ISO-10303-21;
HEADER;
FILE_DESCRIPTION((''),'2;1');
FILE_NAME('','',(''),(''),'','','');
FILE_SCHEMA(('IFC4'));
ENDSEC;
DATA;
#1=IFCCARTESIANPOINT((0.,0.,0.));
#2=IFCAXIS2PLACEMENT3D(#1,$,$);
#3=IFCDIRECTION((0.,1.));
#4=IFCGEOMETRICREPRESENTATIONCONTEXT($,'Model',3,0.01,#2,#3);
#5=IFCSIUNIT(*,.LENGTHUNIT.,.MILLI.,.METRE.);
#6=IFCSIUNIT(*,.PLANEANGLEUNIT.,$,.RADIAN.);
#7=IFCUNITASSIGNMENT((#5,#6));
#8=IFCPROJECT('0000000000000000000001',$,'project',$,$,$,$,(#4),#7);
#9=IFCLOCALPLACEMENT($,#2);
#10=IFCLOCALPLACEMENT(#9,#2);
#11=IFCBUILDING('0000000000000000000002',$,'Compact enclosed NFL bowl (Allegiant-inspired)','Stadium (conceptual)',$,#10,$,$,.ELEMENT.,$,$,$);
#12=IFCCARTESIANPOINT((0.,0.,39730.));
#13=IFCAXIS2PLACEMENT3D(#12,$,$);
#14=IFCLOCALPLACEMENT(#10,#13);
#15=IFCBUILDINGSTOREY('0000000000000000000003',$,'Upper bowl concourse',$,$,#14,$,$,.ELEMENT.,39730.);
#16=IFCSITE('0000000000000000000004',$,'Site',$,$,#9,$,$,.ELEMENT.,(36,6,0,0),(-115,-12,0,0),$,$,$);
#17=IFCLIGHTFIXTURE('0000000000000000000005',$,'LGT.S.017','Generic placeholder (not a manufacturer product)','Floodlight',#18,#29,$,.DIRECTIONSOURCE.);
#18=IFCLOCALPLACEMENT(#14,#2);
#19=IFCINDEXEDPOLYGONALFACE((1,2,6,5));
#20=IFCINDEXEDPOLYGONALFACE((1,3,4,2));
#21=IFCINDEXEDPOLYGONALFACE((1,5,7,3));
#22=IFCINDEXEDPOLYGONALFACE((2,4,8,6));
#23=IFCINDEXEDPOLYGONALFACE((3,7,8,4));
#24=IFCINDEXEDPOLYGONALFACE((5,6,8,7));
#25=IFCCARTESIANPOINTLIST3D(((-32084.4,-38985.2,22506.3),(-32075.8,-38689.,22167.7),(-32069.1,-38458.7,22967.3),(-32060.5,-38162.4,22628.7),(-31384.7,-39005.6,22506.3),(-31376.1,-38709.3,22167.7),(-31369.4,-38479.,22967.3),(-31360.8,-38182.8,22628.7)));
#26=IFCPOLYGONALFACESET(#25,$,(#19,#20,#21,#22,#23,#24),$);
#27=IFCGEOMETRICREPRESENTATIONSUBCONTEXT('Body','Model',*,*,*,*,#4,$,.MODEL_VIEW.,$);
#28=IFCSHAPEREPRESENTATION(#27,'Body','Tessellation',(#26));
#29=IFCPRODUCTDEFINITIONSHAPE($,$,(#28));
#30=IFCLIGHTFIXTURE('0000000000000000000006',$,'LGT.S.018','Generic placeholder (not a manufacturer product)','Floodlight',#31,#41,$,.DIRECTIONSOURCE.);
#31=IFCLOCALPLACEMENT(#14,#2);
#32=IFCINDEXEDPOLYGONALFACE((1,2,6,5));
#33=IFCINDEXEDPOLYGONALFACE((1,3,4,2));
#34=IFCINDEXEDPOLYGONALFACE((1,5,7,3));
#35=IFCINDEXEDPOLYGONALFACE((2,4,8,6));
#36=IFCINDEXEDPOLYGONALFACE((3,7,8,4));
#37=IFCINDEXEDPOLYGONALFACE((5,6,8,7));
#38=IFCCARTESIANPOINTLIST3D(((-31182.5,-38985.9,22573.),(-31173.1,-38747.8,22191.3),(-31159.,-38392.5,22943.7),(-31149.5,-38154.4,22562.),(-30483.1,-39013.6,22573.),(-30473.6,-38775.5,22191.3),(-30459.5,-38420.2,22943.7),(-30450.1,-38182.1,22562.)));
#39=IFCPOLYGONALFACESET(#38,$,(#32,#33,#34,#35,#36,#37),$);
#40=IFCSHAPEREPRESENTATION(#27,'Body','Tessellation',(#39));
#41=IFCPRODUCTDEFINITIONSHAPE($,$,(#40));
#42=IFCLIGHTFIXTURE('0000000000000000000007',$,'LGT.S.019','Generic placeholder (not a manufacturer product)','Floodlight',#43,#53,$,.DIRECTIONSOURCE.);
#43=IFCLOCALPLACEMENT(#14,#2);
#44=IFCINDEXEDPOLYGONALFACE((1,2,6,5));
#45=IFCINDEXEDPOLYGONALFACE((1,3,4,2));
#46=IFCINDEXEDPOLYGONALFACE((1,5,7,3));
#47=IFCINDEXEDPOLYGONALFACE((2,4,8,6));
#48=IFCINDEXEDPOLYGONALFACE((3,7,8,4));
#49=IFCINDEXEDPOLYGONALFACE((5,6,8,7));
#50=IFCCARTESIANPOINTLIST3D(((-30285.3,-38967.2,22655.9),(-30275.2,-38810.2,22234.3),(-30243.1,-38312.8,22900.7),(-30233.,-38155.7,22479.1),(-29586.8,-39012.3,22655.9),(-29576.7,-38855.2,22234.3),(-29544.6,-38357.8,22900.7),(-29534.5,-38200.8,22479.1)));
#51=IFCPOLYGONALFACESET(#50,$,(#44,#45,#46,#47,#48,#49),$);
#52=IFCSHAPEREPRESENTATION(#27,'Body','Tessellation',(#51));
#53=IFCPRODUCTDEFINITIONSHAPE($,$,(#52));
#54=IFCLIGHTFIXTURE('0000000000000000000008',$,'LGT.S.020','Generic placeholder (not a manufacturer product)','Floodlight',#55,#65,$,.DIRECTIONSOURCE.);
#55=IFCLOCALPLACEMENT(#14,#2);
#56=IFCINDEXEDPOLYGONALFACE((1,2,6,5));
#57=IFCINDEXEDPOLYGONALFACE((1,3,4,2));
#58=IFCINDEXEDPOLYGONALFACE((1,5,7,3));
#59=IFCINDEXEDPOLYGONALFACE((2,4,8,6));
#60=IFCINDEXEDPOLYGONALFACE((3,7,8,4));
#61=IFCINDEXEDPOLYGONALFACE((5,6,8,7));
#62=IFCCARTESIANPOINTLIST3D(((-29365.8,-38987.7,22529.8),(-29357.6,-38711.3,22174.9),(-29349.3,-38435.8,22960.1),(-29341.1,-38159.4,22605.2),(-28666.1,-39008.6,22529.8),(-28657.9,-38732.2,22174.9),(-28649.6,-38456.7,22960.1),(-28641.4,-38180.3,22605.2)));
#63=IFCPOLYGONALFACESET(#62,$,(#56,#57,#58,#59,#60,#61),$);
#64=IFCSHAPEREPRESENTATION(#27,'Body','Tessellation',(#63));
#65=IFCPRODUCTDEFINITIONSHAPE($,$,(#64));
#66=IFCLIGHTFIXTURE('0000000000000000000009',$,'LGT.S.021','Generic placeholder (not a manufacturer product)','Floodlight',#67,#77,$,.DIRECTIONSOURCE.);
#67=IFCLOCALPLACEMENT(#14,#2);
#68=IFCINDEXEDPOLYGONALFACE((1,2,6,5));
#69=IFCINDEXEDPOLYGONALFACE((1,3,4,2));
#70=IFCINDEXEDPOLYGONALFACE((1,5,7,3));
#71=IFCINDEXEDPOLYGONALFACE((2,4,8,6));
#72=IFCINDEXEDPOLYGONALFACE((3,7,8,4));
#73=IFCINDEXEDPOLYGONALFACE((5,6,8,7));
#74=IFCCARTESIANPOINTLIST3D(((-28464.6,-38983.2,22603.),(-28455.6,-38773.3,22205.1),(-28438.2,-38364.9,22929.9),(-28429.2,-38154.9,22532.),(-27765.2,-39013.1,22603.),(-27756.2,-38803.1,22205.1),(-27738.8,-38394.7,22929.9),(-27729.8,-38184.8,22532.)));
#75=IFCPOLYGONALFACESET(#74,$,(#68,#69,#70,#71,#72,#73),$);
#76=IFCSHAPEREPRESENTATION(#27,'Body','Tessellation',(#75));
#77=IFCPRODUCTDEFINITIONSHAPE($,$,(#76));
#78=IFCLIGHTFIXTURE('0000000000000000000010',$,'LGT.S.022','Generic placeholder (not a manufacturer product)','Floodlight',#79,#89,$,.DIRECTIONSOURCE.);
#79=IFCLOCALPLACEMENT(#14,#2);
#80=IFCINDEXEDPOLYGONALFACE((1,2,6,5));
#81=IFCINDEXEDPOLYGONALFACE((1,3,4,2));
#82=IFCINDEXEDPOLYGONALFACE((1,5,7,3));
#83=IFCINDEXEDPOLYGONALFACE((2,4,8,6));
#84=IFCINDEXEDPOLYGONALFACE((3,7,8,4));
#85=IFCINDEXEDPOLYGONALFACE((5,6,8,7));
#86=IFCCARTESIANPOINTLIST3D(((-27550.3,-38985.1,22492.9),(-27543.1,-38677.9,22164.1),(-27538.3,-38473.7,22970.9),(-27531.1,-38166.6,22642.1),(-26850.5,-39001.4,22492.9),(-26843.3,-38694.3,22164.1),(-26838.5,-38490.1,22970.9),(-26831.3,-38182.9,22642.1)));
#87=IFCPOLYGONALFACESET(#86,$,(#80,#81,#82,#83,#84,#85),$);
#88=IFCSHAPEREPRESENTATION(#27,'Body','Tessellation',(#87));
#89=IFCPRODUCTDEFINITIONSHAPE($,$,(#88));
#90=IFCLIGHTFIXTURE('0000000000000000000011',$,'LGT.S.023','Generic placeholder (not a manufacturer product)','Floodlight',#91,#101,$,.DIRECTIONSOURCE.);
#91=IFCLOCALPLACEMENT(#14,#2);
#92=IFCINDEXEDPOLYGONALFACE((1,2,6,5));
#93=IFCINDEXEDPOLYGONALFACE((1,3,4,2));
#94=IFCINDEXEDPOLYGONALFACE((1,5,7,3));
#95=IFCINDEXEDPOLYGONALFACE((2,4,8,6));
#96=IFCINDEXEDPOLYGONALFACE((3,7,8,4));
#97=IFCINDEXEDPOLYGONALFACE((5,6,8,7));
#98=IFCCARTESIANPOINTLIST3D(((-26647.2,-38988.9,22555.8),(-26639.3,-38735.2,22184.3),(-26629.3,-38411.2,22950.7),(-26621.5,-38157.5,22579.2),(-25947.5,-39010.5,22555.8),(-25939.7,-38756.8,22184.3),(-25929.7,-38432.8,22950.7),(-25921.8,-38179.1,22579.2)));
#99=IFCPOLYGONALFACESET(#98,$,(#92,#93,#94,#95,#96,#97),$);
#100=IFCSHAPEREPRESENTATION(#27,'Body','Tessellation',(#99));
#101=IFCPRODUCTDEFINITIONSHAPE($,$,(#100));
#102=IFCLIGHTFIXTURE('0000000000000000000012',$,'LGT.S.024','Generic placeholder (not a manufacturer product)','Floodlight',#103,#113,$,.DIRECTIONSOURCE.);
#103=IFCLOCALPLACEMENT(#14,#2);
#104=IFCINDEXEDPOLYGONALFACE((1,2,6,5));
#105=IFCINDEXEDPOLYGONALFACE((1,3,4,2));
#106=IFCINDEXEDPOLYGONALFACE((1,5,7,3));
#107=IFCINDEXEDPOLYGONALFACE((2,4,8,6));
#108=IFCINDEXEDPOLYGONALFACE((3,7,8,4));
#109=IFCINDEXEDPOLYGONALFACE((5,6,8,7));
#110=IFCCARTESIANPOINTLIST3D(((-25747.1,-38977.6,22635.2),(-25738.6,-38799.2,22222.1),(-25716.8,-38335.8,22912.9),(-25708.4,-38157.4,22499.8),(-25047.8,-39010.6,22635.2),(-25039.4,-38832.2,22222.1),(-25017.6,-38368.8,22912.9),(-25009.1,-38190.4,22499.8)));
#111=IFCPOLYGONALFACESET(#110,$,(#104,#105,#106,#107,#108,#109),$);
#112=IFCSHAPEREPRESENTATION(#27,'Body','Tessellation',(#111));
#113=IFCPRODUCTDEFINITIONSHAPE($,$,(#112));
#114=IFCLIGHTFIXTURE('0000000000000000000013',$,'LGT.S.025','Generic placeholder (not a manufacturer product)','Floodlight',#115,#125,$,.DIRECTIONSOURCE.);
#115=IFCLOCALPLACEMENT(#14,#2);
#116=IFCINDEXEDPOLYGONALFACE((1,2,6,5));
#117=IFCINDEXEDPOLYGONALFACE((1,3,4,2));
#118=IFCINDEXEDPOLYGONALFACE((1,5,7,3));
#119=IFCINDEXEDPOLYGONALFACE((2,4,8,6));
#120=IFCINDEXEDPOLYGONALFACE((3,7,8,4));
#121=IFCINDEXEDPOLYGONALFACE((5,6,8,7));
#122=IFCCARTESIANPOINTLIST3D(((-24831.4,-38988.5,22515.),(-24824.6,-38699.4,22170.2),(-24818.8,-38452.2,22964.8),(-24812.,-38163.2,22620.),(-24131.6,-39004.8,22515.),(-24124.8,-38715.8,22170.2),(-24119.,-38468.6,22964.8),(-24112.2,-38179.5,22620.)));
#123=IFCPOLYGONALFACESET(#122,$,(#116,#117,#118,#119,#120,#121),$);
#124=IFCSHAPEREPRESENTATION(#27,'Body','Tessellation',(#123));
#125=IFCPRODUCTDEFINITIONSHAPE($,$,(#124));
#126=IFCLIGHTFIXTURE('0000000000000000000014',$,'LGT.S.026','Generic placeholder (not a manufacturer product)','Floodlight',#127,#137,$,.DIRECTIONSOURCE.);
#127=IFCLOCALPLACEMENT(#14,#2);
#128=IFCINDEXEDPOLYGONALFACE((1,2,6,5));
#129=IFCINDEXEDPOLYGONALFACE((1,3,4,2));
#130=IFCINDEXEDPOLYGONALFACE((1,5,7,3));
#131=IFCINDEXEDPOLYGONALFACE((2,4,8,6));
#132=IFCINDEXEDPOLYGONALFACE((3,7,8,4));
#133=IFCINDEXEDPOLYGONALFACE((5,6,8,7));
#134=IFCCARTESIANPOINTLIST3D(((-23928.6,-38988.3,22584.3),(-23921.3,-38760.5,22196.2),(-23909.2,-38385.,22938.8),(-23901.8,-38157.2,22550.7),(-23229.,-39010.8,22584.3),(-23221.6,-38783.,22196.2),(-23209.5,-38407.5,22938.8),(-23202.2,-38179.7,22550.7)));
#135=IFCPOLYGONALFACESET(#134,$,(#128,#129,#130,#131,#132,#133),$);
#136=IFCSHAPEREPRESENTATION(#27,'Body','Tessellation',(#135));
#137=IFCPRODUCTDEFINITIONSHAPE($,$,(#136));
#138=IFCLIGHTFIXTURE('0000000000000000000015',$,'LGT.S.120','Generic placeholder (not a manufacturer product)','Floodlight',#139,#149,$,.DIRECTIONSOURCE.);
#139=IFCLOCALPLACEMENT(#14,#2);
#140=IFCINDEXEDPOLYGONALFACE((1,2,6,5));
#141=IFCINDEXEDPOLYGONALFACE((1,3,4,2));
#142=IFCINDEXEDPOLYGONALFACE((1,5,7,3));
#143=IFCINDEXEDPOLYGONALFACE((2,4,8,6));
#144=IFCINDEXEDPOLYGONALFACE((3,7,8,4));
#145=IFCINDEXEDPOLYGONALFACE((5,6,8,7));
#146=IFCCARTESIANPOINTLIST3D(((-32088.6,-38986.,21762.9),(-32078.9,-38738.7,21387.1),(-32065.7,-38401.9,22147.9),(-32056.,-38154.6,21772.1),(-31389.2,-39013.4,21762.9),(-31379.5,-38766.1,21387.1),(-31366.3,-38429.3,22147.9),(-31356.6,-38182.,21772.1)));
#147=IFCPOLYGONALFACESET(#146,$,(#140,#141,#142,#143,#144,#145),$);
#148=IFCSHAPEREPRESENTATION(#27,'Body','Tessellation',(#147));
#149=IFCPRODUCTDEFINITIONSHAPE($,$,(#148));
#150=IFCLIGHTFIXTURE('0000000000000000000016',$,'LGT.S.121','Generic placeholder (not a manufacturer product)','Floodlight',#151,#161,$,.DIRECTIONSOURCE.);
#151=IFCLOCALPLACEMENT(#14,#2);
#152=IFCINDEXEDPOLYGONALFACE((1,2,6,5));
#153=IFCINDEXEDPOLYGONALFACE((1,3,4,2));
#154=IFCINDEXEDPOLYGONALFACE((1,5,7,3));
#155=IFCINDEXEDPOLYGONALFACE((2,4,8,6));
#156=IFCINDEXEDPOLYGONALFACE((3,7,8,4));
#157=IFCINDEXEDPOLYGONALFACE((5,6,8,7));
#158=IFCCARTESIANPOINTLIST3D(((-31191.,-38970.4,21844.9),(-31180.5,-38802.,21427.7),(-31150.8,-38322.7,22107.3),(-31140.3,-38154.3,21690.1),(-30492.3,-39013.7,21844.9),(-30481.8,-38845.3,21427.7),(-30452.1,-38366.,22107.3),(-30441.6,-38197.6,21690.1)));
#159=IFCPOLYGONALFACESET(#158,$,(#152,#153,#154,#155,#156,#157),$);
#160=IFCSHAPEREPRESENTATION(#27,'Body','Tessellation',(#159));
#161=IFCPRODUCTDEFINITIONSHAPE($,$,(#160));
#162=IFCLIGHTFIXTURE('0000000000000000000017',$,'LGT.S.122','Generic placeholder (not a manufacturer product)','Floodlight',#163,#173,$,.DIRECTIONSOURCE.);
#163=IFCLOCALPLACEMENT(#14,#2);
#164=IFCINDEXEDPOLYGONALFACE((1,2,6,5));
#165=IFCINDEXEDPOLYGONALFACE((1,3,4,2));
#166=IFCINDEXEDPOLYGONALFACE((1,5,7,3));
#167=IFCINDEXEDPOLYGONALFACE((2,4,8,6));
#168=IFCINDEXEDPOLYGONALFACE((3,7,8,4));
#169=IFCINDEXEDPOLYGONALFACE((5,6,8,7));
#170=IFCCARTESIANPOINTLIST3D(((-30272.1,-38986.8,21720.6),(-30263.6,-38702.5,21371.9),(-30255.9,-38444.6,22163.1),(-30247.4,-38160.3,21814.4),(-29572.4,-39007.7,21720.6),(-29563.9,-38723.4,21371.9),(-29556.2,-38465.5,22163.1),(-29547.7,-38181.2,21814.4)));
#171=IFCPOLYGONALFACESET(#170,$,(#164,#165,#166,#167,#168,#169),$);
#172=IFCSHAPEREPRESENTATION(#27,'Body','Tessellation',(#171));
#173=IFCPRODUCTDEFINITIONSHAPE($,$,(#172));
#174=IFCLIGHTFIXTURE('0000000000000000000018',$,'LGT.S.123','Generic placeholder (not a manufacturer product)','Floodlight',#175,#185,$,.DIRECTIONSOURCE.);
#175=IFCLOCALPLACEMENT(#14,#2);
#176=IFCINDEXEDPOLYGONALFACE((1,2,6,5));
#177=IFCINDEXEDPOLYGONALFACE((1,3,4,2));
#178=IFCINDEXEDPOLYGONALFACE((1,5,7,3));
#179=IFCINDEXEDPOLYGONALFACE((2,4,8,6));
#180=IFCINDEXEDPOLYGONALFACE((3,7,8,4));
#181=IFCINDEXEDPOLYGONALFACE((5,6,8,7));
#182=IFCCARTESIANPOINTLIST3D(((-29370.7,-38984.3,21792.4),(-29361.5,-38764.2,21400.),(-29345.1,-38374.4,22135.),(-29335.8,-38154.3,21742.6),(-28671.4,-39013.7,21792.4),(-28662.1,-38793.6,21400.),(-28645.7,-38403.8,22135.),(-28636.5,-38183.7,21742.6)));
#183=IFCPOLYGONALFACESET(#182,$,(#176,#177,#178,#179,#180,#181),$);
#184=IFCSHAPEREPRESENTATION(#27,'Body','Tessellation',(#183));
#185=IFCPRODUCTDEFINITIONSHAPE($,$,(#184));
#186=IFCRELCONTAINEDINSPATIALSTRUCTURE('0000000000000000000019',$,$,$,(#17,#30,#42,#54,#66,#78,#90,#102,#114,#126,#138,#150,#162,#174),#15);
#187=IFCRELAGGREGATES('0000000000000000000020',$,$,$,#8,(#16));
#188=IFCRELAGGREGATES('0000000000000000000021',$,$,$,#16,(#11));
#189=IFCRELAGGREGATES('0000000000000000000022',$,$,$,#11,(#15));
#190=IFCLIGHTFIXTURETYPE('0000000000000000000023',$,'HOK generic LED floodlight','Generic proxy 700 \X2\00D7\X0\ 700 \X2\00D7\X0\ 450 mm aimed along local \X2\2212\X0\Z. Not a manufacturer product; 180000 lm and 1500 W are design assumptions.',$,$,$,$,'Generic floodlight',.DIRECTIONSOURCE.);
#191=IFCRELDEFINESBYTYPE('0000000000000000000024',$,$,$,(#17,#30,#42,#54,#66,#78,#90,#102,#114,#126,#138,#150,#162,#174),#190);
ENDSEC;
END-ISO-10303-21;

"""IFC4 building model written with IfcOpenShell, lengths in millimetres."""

from ifc_helpers import new_model, si_unit, direction, frame, origin, place, context, subcontext, project, spatial, rectangle, extrude, source, transform, mapped, type_object, type_shapes, element, save


model = new_model("IFC4")

# Units and contexts
model_context = context("Model", 3, precision=0.01, world=origin(), true_north=direction((0.0, 1.0)))
body_context = subcontext(model_context, "Body", "Model", "MODEL_VIEW")
ifc_project = project(units=[si_unit("LENGTHUNIT", "METRE", prefix="MILLI"), si_unit("PLANEANGLEUNIT", "RADIAN")], contexts=[model_context])

# Site, building, storey
site_placement = place(None, origin())
site = spatial("IfcSite", under=ifc_project, at=site_placement, Name="Site", CompositionType="ELEMENT", RefLatitude=(36, 6, 0, 0), RefLongitude=(-115, -12, 0, 0))
building_placement = place(site_placement, origin())
building = spatial("IfcBuilding", under=site, at=building_placement, Name="Compact enclosed NFL bowl (Allegiant-inspired)", Description="Stadium (conceptual)", CompositionType="ELEMENT")
storey_placement = place(building_placement, frame((0.0, 0.0, 39730.0)))
storey = spatial("IfcBuildingStorey", under=building, at=storey_placement, Name="Upper bowl concourse", CompositionType="ELEMENT", Elevation=39730.0)

# Light fixtures
light_fixture_type = type_object("IfcLightFixtureType", Name="HOK generic LED floodlight", Description="Generic proxy 700 × 700 × 450 mm aimed along local −Z. Not a manufacturer product; 180000 lm and 1500 W are design assumptions.", ElementType="Generic floodlight", PredefinedType="DIRECTIONSOURCE")
shared_shape = source(origin(), body_context, "Body", "SweptSolid", [
    extrude(rectangle(XDim=700.0, YDim=700.0), frame((0.0, 0.0, -225.0)), (0.0, 0.0, 1.0), 450.0),
])
type_shapes(light_fixture_type, [shared_shape])
for number, where, z_axis, x_axis, name in (
    (1, (-31722.6, -38584.0, 22567.5), (-0.019159, -0.658318, 0.752496), (0.999577, -0.029091, 0.0), "LGT.S.017"),
    (2, (-30816.3, -38584.0, 22567.5), (-0.020982, -0.529075, 0.848316), (0.999215, -0.039626, 0.0), "LGT.S.018"),
    (3, (-29909.9, -38584.0, 22567.5), (-0.02249, -0.348985, 0.936858), (0.99793, -0.06431, 0.0), "LGT.S.019"),
    (4, (-29003.6, -38584.0, 22567.5), (-0.018362, -0.614392, 0.788787), (0.999554, -0.029872, 0.0), "LGT.S.020"),
    (5, (-28097.2, -38584.0, 22567.5), (-0.01994, -0.466638, 0.884224), (0.999088, -0.042692, 0.0), "LGT.S.021"),
    (6, (-27190.8, -38584.0, 22567.5), (-0.015946, -0.682546, 0.730668), (0.999727, -0.023356, 0.0), "LGT.S.022"),
    (7, (-26284.5, -38584.0, 22567.5), (-0.017418, -0.5639, 0.825659), (0.999523, -0.030874, 0.0), "LGT.S.023"),
    (8, (-25378.1, -38584.0, 22567.5), (-0.018696, -0.396352, 0.917908), (0.998889, -0.047119, 0.0), "LGT.S.024"),
    (9, (-24471.8, -38584.0, 22567.5), (-0.015051, -0.642311, 0.766296), (0.999726, -0.023426, 0.0), "LGT.S.025"),
    (10, (-23565.4, -38584.0, 22567.5), (-0.016309, -0.506181, 0.862273), (0.999481, -0.032202, 0.0), "LGT.S.026"),
    (11, (-31722.6, -38584.0, 21767.5), (-0.02154, -0.549597, 0.835152), (0.999233, -0.039163, 0.0), "LGT.S.120"),
    (12, (-30816.3, -38584.0, 21767.5), (-0.023227, -0.374199, 0.927058), (0.998079, -0.061953, 0.0), "LGT.S.121"),
    (13, (-29909.9, -38584.0, 21767.5), (-0.018844, -0.631801, 0.774902), (0.999556, -0.029813, 0.0), "LGT.S.122"),
    (14, (-29003.6, -38584.0, 21767.5), (-0.020562, -0.489093, 0.871989), (0.999117, -0.042005, 0.0), "LGT.S.123"),
):
    element("IfcLightFixture", number, at=place(storey_placement, frame(where, z_axis=z_axis, x_axis=x_axis)), inside=storey, type_object=light_fixture_type, Name=name, Description="Generic placeholder (not a manufacturer product)", ObjectType="Floodlight", PredefinedType="DIRECTIONSOURCE", context=body_context, shape_type="MappedRepresentation", body=[
        mapped(shared_shape, transform((0.0, 0.0, 0.0))),
    ])

save(model, "model.ifc")
